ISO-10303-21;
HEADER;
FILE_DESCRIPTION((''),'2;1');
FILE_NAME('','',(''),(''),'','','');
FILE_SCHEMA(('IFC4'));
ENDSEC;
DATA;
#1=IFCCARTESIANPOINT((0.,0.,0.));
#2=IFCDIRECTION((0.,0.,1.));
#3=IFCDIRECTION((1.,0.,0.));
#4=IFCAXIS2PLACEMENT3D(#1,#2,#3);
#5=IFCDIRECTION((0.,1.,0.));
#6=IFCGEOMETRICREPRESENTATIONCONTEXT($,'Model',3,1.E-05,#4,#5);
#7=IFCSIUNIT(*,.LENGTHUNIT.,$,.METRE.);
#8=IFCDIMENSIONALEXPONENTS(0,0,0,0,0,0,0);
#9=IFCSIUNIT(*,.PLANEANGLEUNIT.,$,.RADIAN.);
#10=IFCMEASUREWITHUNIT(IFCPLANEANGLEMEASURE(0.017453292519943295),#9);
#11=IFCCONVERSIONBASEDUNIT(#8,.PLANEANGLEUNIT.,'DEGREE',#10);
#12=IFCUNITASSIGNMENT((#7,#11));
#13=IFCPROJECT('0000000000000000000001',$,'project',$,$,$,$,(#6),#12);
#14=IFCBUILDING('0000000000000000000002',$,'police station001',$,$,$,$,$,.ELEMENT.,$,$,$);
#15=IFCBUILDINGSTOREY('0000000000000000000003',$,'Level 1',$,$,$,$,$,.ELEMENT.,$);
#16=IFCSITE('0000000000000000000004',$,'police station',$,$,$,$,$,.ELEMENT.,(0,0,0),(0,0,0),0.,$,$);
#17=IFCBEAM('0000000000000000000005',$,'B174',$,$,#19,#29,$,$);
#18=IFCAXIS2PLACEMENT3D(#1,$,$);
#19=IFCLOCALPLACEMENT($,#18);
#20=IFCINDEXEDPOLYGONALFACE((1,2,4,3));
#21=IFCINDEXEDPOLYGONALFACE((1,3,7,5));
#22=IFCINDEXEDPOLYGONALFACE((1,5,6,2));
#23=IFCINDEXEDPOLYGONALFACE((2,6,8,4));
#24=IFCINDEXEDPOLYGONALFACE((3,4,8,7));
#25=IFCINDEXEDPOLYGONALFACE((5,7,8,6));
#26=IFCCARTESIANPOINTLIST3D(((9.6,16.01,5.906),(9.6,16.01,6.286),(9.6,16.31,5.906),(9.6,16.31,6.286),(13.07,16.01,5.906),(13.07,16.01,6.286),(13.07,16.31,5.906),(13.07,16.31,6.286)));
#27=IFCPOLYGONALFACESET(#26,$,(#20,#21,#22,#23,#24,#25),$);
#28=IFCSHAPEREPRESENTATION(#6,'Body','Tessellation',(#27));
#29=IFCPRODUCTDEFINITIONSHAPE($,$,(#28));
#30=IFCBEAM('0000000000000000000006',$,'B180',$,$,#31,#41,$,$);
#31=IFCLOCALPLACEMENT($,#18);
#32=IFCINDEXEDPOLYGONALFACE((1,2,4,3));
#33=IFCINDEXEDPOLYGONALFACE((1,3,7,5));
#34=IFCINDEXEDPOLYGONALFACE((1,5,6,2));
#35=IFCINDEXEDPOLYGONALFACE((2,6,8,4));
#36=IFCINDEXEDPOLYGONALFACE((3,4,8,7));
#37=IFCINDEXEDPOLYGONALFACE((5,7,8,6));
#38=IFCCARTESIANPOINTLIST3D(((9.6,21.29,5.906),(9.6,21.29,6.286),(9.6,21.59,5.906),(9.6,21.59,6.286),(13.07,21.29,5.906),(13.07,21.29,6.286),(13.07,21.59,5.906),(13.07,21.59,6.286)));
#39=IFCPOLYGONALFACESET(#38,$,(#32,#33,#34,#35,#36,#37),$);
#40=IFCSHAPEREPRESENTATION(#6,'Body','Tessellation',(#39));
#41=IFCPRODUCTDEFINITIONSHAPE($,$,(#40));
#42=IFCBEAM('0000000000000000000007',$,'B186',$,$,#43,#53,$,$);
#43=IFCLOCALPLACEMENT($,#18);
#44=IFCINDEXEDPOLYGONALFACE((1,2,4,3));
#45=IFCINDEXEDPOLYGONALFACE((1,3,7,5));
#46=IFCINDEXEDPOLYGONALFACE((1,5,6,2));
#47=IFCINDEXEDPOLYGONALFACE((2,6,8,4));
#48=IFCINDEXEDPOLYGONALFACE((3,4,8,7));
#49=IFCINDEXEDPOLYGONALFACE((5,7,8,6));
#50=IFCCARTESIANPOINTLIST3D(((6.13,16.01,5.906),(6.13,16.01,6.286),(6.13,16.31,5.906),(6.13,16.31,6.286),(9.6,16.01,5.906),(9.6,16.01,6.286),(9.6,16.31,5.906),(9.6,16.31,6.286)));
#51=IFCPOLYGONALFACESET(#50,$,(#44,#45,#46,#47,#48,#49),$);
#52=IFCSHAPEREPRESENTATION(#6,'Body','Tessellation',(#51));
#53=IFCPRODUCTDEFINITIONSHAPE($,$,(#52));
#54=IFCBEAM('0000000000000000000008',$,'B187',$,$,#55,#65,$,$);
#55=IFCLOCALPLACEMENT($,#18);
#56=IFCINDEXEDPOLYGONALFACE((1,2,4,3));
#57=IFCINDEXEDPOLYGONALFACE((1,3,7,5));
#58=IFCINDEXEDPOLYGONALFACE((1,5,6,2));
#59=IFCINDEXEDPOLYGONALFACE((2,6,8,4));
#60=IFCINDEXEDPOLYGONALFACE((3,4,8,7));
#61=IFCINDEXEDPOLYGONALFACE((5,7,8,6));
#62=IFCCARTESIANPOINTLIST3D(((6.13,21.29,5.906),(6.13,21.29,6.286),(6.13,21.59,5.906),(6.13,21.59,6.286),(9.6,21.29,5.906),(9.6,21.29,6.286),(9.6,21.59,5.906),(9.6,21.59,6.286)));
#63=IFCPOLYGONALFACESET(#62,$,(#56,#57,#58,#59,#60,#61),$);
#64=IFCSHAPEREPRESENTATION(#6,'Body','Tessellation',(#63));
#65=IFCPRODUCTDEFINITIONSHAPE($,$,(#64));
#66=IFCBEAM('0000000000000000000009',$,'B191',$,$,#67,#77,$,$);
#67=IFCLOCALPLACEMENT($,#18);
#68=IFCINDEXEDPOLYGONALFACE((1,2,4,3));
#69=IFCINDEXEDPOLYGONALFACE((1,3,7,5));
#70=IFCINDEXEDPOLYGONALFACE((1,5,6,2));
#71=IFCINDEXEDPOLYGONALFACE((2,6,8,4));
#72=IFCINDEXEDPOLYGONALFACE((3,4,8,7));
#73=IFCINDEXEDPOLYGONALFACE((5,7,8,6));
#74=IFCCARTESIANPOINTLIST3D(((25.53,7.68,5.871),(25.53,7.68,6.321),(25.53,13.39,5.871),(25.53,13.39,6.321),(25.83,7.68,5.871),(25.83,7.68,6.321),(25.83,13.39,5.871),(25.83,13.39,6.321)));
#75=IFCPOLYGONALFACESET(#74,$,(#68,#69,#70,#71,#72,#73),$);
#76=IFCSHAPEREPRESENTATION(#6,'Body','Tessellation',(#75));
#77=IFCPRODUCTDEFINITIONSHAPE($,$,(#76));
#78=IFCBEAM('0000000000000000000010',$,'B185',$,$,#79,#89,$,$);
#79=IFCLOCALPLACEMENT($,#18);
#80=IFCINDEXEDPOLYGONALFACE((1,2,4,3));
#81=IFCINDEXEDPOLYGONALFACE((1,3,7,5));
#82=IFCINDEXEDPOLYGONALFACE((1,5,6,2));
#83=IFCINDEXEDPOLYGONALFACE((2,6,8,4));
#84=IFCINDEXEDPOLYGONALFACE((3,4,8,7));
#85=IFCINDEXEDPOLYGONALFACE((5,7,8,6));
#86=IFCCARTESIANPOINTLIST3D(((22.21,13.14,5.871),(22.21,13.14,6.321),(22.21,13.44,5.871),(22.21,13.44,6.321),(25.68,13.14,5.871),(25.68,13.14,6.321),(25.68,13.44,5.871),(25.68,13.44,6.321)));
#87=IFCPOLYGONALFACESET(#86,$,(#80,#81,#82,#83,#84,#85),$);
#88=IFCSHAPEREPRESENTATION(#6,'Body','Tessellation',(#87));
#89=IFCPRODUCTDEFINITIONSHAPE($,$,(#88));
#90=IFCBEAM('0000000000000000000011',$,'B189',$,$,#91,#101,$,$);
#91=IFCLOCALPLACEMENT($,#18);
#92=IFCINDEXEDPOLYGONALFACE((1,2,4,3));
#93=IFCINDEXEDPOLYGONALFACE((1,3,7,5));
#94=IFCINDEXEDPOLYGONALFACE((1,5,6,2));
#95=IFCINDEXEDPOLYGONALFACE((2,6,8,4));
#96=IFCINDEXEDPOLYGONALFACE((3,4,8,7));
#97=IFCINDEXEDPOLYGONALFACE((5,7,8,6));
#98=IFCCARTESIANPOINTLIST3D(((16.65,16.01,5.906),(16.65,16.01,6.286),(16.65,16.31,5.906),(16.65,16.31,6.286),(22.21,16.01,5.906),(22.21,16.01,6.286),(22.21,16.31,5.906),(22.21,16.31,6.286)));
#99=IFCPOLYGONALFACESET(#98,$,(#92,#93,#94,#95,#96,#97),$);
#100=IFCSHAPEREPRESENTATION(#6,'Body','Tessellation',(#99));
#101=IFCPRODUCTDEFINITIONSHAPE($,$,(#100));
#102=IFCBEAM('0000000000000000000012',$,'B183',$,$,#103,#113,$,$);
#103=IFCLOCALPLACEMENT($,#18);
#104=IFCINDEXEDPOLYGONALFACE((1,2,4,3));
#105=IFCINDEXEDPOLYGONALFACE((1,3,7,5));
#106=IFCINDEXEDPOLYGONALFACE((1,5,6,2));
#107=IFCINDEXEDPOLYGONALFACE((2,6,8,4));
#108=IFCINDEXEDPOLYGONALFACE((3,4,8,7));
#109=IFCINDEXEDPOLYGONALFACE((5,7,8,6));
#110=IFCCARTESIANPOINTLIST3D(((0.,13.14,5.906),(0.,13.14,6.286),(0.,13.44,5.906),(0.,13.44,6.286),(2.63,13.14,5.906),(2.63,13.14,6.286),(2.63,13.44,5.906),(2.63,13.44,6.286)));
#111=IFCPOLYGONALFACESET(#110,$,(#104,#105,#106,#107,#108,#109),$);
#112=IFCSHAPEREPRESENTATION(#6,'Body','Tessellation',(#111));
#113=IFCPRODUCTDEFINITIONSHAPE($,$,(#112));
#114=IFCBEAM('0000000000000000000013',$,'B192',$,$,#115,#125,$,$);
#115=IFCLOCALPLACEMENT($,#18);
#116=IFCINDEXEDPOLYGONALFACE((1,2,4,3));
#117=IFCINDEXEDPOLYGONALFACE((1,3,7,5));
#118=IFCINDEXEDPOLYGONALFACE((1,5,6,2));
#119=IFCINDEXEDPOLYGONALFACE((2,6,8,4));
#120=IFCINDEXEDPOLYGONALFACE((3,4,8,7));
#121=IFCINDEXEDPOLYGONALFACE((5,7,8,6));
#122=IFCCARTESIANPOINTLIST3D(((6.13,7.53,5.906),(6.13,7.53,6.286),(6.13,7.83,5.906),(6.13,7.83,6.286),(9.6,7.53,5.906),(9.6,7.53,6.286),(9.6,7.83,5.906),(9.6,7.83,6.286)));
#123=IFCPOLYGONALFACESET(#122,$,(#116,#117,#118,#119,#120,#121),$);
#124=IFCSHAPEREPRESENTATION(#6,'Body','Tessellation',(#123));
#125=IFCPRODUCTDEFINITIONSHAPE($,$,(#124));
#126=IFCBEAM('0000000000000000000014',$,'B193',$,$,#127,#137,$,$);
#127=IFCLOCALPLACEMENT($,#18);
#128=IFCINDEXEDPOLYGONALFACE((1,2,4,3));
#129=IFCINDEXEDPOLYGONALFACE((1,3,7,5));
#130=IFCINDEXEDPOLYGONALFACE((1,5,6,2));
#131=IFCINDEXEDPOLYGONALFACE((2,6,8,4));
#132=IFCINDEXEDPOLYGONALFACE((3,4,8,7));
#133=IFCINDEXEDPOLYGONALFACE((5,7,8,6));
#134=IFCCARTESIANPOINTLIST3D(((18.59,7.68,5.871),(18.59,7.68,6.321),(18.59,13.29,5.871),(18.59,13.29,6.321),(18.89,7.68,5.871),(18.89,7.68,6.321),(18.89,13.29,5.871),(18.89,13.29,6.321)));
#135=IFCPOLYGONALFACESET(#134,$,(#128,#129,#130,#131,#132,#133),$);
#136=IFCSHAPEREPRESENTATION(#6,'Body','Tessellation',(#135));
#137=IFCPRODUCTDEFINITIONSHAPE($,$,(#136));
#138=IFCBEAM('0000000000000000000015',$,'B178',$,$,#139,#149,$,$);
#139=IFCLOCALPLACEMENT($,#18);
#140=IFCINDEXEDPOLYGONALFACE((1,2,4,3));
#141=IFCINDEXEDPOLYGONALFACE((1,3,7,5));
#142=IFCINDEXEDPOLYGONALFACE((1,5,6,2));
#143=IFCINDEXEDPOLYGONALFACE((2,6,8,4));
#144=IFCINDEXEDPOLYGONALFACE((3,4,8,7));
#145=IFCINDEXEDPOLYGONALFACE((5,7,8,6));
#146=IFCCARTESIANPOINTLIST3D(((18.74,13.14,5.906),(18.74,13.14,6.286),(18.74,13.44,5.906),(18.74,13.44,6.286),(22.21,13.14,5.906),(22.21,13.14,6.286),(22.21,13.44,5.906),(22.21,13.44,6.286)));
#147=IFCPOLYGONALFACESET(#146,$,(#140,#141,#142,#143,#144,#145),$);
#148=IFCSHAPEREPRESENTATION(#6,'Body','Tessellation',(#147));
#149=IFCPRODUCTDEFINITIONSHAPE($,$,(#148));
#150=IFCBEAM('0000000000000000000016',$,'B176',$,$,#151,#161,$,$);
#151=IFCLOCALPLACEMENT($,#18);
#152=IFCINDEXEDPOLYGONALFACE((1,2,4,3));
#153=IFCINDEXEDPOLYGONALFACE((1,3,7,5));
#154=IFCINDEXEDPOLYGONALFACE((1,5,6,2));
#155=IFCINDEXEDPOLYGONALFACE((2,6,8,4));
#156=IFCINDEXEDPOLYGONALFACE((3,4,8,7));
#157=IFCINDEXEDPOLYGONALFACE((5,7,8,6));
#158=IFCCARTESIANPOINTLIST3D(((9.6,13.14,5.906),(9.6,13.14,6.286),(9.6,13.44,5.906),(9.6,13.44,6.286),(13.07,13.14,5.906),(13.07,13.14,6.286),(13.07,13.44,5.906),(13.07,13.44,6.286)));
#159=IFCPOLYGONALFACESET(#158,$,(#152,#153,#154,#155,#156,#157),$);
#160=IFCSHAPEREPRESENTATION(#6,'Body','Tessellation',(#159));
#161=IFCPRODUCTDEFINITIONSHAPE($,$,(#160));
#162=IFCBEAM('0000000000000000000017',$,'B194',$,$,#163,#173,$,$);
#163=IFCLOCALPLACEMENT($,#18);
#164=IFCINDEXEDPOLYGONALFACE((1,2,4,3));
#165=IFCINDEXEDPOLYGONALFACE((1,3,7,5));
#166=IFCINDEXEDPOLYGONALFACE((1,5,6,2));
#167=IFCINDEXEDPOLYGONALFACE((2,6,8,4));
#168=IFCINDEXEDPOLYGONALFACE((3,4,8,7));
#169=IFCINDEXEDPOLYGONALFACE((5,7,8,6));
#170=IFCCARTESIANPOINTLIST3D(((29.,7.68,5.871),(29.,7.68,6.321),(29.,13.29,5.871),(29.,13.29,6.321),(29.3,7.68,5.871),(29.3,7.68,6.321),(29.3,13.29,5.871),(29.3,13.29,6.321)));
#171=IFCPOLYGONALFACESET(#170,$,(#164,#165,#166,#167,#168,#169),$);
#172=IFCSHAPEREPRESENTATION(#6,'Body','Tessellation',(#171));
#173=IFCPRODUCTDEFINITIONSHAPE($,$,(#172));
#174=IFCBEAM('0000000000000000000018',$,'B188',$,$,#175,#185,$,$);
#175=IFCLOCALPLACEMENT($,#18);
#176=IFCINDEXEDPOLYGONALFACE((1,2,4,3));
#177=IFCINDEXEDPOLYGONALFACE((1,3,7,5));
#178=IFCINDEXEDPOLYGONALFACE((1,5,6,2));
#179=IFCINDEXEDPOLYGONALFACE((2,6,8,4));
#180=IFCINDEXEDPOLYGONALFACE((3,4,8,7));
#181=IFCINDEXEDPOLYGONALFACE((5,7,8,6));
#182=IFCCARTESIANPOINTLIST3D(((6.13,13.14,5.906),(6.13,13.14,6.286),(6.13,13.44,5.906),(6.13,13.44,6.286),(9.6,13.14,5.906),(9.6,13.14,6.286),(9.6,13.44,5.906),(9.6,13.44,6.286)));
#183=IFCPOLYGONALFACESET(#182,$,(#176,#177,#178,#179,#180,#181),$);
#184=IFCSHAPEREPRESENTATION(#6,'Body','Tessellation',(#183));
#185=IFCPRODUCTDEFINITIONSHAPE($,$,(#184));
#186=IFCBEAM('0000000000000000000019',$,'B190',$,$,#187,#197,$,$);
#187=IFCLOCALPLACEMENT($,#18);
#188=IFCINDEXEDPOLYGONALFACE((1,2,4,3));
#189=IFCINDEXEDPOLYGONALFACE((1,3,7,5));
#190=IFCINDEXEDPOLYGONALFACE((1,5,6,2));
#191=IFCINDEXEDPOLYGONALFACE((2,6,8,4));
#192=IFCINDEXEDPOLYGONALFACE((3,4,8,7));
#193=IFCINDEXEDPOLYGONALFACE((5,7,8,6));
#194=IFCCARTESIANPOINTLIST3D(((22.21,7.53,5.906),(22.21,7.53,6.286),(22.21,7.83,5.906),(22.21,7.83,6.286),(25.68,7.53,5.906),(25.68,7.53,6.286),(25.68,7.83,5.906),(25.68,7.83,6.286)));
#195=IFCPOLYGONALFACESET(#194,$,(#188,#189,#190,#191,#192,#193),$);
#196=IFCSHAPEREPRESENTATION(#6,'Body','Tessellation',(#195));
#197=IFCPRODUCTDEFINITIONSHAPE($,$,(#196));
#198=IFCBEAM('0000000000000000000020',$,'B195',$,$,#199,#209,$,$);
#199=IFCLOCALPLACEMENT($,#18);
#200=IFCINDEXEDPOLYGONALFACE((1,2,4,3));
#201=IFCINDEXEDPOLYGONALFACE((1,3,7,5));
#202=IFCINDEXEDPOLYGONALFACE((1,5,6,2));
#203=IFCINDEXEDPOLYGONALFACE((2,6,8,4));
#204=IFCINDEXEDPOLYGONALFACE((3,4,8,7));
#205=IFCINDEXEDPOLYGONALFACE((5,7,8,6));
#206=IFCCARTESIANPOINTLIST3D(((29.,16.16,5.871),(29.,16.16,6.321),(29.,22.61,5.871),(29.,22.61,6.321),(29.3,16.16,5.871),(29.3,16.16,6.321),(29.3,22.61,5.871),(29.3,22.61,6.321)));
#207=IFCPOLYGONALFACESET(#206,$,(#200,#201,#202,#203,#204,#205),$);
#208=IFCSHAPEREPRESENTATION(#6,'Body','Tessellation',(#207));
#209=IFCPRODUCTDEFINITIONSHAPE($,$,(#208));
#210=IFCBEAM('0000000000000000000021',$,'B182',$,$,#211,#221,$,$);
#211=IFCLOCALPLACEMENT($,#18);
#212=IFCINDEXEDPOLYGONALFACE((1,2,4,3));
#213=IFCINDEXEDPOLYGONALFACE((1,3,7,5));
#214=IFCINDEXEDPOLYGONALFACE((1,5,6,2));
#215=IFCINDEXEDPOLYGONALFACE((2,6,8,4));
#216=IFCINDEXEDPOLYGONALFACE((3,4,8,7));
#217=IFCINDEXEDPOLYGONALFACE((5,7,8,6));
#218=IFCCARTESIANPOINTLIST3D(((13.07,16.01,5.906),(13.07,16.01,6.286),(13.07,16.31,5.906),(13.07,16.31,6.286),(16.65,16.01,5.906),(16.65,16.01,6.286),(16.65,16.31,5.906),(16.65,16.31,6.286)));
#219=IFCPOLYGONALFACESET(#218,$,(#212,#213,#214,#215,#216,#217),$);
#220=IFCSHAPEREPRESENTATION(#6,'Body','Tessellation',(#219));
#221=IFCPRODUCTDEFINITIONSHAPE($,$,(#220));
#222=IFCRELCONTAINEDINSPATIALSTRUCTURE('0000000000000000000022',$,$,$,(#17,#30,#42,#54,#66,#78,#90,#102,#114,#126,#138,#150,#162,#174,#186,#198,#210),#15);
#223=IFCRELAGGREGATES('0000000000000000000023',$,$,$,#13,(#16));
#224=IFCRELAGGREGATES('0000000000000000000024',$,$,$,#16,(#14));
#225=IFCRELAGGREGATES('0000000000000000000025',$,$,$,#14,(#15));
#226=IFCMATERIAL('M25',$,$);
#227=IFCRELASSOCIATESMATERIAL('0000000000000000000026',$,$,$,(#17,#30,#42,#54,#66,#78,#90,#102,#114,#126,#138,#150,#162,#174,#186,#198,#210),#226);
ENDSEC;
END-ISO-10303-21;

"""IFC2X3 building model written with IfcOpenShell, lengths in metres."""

from ifc_helpers import new_model, entity, si_unit, converted_unit, direction, frame, frame_2d, origin_with_axes, place, context, project, spatial, rectangle, extrude, material, element, save


model = new_model("IFC2X3")

# Units and contexts
model_context = context("Model", 3, precision=1e-05, world=origin_with_axes(), true_north=direction((0.0, 1.0, 0.0)))
ifc_project = project(units=[si_unit("LENGTHUNIT", "METRE"), converted_unit("PLANEANGLEUNIT", "DEGREE", entity("IfcPlaneAngleMeasure", 0.017453292519943295), si_unit("PLANEANGLEUNIT", "RADIAN"), dimensions=[0, 0, 0, 0, 0, 0, 0])], contexts=[model_context])

# Site, building, storey
site = spatial("IfcSite", under=ifc_project, Name="police station", CompositionType="ELEMENT", RefLatitude=(0, 0, 0), RefLongitude=(0, 0, 0), RefElevation=0.0)
building = spatial("IfcBuilding", under=site, Name="police station001", CompositionType="ELEMENT")
storey = spatial("IfcBuildingStorey", under=building, Name="Level 1", CompositionType="ELEMENT")

# Shared definitions
ifc_material = material(Name="M25")
placement = place(None, origin_with_axes())

# Beams
element("IfcBeam", 1, at=placement, inside=storey, material=ifc_material, Name="B174", context=model_context, shape_type="SweptSolid", body=[
    extrude(rectangle(XDim=0.3, YDim=0.38, at=frame_2d((0.0, 0.0), x_axis=(0.0, 1.0, 0.0))), frame((13.07, 16.16, 6.096), z_axis=(-1.0, 0.0, 0.0), x_axis=(0.0, 0.0, -1.0)), (0.0, 0.0, 1.0), 3.47),
])
element("IfcBeam", 2, at=placement, inside=storey, material=ifc_material, Name="B180", context=model_context, shape_type="SweptSolid", body=[
    extrude(rectangle(XDim=0.3, YDim=0.38, at=frame_2d((0.0, 0.0), x_axis=(0.0, 1.0, 0.0))), frame((13.07, 21.44, 6.096), z_axis=(-1.0, 0.0, 0.0), x_axis=(0.0, 0.0, -1.0)), (0.0, 0.0, 1.0), 3.47),
])
element("IfcBeam", 3, at=placement, inside=storey, material=ifc_material, Name="B186", context=model_context, shape_type="SweptSolid", body=[
    extrude(rectangle(XDim=0.3, YDim=0.38, at=frame_2d((0.0, 0.0), x_axis=(0.0, 1.0, 0.0))), frame((9.6, 16.16, 6.096), z_axis=(-1.0, 0.0, 0.0), x_axis=(0.0, 0.0, -1.0)), (0.0, 0.0, 1.0), 3.47),
])
element("IfcBeam", 4, at=placement, inside=storey, material=ifc_material, Name="B187", context=model_context, shape_type="SweptSolid", body=[
    extrude(rectangle(XDim=0.3, YDim=0.38, at=frame_2d((0.0, 0.0), x_axis=(0.0, 1.0, 0.0))), frame((9.6, 21.44, 6.096), z_axis=(-1.0, 0.0, 0.0), x_axis=(0.0, 0.0, -1.0)), (0.0, 0.0, 1.0), 3.47),
])
element("IfcBeam", 5, at=placement, inside=storey, material=ifc_material, Name="B191", context=model_context, shape_type="SweptSolid", body=[
    extrude(rectangle(XDim=0.3, YDim=0.45, at=frame_2d((0.0, 0.0), x_axis=(0.0, 1.0, 0.0))), frame((25.68, 7.68, 6.096), z_axis=(0.0, 1.0, 0.0), x_axis=(0.0, 0.0, -1.0)), (0.0, 0.0, 1.0), 5.71),
])
element("IfcBeam", 6, at=placement, inside=storey, material=ifc_material, Name="B185", context=model_context, shape_type="SweptSolid", body=[
    extrude(rectangle(XDim=0.3, YDim=0.45, at=frame_2d((0.0, 0.0), x_axis=(0.0, 1.0, 0.0))), frame((25.68, 13.29, 6.096), z_axis=(-1.0, 0.0, 0.0), x_axis=(0.0, 0.0, -1.0)), (0.0, 0.0, 1.0), 3.47),
])
element("IfcBeam", 7, at=placement, inside=storey, material=ifc_material, Name="B189", context=model_context, shape_type="SweptSolid", body=[
    extrude(rectangle(XDim=0.3, YDim=0.38, at=frame_2d((0.0, 0.0), x_axis=(0.0, 1.0, 0.0))), frame((22.21, 16.16, 6.096), z_axis=(-1.0, 0.0, 0.0), x_axis=(0.0, 0.0, -1.0)), (0.0, 0.0, 1.0), 5.56),
])
element("IfcBeam", 8, at=placement, inside=storey, material=ifc_material, Name="B183", context=model_context, shape_type="SweptSolid", body=[
    extrude(rectangle(XDim=0.3, YDim=0.38, at=frame_2d((0.0, 0.0), x_axis=(0.0, 1.0, 0.0))), frame((0.0, 13.29, 6.096), z_axis=(1.0, 0.0, 0.0), x_axis=(0.0, 0.0, -1.0)), (0.0, 0.0, 1.0), 2.63),
])
element("IfcBeam", 9, at=placement, inside=storey, material=ifc_material, Name="B192", context=model_context, shape_type="SweptSolid", body=[
    extrude(rectangle(XDim=0.3, YDim=0.38, at=frame_2d((0.0, 0.0), x_axis=(0.0, 1.0, 0.0))), frame((6.13, 7.68, 6.096), z_axis=(1.0, 0.0, 0.0), x_axis=(0.0, 0.0, -1.0)), (0.0, 0.0, 1.0), 3.47),
])
element("IfcBeam", 10, at=placement, inside=storey, material=ifc_material, Name="B193", context=model_context, shape_type="SweptSolid", body=[
    extrude(rectangle(XDim=0.3, YDim=0.45, at=frame_2d((0.0, 0.0), x_axis=(0.0, 1.0, 0.0))), frame((18.74, 13.29, 6.096), z_axis=(0.0, -1.0, 0.0), x_axis=(0.0, 0.0, -1.0)), (0.0, 0.0, 1.0), 5.61),
])
element("IfcBeam", 11, at=placement, inside=storey, material=ifc_material, Name="B178", context=model_context, shape_type="SweptSolid", body=[
    extrude(rectangle(XDim=0.3, YDim=0.38, at=frame_2d((0.0, 0.0), x_axis=(0.0, 1.0, 0.0))), frame((22.21, 13.29, 6.096), z_axis=(-1.0, 0.0, 0.0), x_axis=(0.0, 0.0, -1.0)), (0.0, 0.0, 1.0), 3.47),
])
element("IfcBeam", 12, at=placement, inside=storey, material=ifc_material, Name="B176", context=model_context, shape_type="SweptSolid", body=[
    extrude(rectangle(XDim=0.3, YDim=0.38, at=frame_2d((0.0, 0.0), x_axis=(0.0, 1.0, 0.0))), frame((13.07, 13.29, 6.096), z_axis=(-1.0, 0.0, 0.0), x_axis=(0.0, 0.0, -1.0)), (0.0, 0.0, 1.0), 3.47),
])
element("IfcBeam", 13, at=placement, inside=storey, material=ifc_material, Name="B194", context=model_context, shape_type="SweptSolid", body=[
    extrude(rectangle(XDim=0.3, YDim=0.45, at=frame_2d((0.0, 0.0), x_axis=(0.0, 1.0, 0.0))), frame((29.15, 13.29, 6.096), z_axis=(0.0, -1.0, 0.0), x_axis=(0.0, 0.0, -1.0)), (0.0, 0.0, 1.0), 5.61),
])
element("IfcBeam", 14, at=placement, inside=storey, material=ifc_material, Name="B188", context=model_context, shape_type="SweptSolid", body=[
    extrude(rectangle(XDim=0.3, YDim=0.38, at=frame_2d((0.0, 0.0), x_axis=(0.0, 1.0, 0.0))), frame((9.6, 13.29, 6.096), z_axis=(-1.0, 0.0, 0.0), x_axis=(0.0, 0.0, -1.0)), (0.0, 0.0, 1.0), 3.47),
])
element("IfcBeam", 15, at=placement, inside=storey, material=ifc_material, Name="B190", context=model_context, shape_type="SweptSolid", body=[
    extrude(rectangle(XDim=0.3, YDim=0.38, at=frame_2d((0.0, 0.0), x_axis=(0.0, 1.0, 0.0))), frame((25.68, 7.68, 6.096), z_axis=(-1.0, 0.0, 0.0), x_axis=(0.0, 0.0, -1.0)), (0.0, 0.0, 1.0), 3.47),
])
element("IfcBeam", 16, at=placement, inside=storey, material=ifc_material, Name="B195", context=model_context, shape_type="SweptSolid", body=[
    extrude(rectangle(XDim=0.3, YDim=0.45, at=frame_2d((0.0, 0.0), x_axis=(0.0, 1.0, 0.0))), frame((29.15, 16.16, 6.096), z_axis=(0.0, 1.0, 0.0), x_axis=(0.0, 0.0, -1.0)), (0.0, 0.0, 1.0), 6.45),
])
element("IfcBeam", 17, at=placement, inside=storey, material=ifc_material, Name="B182", context=model_context, shape_type="SweptSolid", body=[
    extrude(rectangle(XDim=0.3, YDim=0.38, at=frame_2d((0.0, 0.0), x_axis=(0.0, 1.0, 0.0))), frame((16.65, 16.16, 6.096), z_axis=(-1.0, 0.0, 0.0), x_axis=(0.0, 0.0, -1.0)), (0.0, 0.0, 1.0), 3.58),
])

save(model, "model.ifc")
